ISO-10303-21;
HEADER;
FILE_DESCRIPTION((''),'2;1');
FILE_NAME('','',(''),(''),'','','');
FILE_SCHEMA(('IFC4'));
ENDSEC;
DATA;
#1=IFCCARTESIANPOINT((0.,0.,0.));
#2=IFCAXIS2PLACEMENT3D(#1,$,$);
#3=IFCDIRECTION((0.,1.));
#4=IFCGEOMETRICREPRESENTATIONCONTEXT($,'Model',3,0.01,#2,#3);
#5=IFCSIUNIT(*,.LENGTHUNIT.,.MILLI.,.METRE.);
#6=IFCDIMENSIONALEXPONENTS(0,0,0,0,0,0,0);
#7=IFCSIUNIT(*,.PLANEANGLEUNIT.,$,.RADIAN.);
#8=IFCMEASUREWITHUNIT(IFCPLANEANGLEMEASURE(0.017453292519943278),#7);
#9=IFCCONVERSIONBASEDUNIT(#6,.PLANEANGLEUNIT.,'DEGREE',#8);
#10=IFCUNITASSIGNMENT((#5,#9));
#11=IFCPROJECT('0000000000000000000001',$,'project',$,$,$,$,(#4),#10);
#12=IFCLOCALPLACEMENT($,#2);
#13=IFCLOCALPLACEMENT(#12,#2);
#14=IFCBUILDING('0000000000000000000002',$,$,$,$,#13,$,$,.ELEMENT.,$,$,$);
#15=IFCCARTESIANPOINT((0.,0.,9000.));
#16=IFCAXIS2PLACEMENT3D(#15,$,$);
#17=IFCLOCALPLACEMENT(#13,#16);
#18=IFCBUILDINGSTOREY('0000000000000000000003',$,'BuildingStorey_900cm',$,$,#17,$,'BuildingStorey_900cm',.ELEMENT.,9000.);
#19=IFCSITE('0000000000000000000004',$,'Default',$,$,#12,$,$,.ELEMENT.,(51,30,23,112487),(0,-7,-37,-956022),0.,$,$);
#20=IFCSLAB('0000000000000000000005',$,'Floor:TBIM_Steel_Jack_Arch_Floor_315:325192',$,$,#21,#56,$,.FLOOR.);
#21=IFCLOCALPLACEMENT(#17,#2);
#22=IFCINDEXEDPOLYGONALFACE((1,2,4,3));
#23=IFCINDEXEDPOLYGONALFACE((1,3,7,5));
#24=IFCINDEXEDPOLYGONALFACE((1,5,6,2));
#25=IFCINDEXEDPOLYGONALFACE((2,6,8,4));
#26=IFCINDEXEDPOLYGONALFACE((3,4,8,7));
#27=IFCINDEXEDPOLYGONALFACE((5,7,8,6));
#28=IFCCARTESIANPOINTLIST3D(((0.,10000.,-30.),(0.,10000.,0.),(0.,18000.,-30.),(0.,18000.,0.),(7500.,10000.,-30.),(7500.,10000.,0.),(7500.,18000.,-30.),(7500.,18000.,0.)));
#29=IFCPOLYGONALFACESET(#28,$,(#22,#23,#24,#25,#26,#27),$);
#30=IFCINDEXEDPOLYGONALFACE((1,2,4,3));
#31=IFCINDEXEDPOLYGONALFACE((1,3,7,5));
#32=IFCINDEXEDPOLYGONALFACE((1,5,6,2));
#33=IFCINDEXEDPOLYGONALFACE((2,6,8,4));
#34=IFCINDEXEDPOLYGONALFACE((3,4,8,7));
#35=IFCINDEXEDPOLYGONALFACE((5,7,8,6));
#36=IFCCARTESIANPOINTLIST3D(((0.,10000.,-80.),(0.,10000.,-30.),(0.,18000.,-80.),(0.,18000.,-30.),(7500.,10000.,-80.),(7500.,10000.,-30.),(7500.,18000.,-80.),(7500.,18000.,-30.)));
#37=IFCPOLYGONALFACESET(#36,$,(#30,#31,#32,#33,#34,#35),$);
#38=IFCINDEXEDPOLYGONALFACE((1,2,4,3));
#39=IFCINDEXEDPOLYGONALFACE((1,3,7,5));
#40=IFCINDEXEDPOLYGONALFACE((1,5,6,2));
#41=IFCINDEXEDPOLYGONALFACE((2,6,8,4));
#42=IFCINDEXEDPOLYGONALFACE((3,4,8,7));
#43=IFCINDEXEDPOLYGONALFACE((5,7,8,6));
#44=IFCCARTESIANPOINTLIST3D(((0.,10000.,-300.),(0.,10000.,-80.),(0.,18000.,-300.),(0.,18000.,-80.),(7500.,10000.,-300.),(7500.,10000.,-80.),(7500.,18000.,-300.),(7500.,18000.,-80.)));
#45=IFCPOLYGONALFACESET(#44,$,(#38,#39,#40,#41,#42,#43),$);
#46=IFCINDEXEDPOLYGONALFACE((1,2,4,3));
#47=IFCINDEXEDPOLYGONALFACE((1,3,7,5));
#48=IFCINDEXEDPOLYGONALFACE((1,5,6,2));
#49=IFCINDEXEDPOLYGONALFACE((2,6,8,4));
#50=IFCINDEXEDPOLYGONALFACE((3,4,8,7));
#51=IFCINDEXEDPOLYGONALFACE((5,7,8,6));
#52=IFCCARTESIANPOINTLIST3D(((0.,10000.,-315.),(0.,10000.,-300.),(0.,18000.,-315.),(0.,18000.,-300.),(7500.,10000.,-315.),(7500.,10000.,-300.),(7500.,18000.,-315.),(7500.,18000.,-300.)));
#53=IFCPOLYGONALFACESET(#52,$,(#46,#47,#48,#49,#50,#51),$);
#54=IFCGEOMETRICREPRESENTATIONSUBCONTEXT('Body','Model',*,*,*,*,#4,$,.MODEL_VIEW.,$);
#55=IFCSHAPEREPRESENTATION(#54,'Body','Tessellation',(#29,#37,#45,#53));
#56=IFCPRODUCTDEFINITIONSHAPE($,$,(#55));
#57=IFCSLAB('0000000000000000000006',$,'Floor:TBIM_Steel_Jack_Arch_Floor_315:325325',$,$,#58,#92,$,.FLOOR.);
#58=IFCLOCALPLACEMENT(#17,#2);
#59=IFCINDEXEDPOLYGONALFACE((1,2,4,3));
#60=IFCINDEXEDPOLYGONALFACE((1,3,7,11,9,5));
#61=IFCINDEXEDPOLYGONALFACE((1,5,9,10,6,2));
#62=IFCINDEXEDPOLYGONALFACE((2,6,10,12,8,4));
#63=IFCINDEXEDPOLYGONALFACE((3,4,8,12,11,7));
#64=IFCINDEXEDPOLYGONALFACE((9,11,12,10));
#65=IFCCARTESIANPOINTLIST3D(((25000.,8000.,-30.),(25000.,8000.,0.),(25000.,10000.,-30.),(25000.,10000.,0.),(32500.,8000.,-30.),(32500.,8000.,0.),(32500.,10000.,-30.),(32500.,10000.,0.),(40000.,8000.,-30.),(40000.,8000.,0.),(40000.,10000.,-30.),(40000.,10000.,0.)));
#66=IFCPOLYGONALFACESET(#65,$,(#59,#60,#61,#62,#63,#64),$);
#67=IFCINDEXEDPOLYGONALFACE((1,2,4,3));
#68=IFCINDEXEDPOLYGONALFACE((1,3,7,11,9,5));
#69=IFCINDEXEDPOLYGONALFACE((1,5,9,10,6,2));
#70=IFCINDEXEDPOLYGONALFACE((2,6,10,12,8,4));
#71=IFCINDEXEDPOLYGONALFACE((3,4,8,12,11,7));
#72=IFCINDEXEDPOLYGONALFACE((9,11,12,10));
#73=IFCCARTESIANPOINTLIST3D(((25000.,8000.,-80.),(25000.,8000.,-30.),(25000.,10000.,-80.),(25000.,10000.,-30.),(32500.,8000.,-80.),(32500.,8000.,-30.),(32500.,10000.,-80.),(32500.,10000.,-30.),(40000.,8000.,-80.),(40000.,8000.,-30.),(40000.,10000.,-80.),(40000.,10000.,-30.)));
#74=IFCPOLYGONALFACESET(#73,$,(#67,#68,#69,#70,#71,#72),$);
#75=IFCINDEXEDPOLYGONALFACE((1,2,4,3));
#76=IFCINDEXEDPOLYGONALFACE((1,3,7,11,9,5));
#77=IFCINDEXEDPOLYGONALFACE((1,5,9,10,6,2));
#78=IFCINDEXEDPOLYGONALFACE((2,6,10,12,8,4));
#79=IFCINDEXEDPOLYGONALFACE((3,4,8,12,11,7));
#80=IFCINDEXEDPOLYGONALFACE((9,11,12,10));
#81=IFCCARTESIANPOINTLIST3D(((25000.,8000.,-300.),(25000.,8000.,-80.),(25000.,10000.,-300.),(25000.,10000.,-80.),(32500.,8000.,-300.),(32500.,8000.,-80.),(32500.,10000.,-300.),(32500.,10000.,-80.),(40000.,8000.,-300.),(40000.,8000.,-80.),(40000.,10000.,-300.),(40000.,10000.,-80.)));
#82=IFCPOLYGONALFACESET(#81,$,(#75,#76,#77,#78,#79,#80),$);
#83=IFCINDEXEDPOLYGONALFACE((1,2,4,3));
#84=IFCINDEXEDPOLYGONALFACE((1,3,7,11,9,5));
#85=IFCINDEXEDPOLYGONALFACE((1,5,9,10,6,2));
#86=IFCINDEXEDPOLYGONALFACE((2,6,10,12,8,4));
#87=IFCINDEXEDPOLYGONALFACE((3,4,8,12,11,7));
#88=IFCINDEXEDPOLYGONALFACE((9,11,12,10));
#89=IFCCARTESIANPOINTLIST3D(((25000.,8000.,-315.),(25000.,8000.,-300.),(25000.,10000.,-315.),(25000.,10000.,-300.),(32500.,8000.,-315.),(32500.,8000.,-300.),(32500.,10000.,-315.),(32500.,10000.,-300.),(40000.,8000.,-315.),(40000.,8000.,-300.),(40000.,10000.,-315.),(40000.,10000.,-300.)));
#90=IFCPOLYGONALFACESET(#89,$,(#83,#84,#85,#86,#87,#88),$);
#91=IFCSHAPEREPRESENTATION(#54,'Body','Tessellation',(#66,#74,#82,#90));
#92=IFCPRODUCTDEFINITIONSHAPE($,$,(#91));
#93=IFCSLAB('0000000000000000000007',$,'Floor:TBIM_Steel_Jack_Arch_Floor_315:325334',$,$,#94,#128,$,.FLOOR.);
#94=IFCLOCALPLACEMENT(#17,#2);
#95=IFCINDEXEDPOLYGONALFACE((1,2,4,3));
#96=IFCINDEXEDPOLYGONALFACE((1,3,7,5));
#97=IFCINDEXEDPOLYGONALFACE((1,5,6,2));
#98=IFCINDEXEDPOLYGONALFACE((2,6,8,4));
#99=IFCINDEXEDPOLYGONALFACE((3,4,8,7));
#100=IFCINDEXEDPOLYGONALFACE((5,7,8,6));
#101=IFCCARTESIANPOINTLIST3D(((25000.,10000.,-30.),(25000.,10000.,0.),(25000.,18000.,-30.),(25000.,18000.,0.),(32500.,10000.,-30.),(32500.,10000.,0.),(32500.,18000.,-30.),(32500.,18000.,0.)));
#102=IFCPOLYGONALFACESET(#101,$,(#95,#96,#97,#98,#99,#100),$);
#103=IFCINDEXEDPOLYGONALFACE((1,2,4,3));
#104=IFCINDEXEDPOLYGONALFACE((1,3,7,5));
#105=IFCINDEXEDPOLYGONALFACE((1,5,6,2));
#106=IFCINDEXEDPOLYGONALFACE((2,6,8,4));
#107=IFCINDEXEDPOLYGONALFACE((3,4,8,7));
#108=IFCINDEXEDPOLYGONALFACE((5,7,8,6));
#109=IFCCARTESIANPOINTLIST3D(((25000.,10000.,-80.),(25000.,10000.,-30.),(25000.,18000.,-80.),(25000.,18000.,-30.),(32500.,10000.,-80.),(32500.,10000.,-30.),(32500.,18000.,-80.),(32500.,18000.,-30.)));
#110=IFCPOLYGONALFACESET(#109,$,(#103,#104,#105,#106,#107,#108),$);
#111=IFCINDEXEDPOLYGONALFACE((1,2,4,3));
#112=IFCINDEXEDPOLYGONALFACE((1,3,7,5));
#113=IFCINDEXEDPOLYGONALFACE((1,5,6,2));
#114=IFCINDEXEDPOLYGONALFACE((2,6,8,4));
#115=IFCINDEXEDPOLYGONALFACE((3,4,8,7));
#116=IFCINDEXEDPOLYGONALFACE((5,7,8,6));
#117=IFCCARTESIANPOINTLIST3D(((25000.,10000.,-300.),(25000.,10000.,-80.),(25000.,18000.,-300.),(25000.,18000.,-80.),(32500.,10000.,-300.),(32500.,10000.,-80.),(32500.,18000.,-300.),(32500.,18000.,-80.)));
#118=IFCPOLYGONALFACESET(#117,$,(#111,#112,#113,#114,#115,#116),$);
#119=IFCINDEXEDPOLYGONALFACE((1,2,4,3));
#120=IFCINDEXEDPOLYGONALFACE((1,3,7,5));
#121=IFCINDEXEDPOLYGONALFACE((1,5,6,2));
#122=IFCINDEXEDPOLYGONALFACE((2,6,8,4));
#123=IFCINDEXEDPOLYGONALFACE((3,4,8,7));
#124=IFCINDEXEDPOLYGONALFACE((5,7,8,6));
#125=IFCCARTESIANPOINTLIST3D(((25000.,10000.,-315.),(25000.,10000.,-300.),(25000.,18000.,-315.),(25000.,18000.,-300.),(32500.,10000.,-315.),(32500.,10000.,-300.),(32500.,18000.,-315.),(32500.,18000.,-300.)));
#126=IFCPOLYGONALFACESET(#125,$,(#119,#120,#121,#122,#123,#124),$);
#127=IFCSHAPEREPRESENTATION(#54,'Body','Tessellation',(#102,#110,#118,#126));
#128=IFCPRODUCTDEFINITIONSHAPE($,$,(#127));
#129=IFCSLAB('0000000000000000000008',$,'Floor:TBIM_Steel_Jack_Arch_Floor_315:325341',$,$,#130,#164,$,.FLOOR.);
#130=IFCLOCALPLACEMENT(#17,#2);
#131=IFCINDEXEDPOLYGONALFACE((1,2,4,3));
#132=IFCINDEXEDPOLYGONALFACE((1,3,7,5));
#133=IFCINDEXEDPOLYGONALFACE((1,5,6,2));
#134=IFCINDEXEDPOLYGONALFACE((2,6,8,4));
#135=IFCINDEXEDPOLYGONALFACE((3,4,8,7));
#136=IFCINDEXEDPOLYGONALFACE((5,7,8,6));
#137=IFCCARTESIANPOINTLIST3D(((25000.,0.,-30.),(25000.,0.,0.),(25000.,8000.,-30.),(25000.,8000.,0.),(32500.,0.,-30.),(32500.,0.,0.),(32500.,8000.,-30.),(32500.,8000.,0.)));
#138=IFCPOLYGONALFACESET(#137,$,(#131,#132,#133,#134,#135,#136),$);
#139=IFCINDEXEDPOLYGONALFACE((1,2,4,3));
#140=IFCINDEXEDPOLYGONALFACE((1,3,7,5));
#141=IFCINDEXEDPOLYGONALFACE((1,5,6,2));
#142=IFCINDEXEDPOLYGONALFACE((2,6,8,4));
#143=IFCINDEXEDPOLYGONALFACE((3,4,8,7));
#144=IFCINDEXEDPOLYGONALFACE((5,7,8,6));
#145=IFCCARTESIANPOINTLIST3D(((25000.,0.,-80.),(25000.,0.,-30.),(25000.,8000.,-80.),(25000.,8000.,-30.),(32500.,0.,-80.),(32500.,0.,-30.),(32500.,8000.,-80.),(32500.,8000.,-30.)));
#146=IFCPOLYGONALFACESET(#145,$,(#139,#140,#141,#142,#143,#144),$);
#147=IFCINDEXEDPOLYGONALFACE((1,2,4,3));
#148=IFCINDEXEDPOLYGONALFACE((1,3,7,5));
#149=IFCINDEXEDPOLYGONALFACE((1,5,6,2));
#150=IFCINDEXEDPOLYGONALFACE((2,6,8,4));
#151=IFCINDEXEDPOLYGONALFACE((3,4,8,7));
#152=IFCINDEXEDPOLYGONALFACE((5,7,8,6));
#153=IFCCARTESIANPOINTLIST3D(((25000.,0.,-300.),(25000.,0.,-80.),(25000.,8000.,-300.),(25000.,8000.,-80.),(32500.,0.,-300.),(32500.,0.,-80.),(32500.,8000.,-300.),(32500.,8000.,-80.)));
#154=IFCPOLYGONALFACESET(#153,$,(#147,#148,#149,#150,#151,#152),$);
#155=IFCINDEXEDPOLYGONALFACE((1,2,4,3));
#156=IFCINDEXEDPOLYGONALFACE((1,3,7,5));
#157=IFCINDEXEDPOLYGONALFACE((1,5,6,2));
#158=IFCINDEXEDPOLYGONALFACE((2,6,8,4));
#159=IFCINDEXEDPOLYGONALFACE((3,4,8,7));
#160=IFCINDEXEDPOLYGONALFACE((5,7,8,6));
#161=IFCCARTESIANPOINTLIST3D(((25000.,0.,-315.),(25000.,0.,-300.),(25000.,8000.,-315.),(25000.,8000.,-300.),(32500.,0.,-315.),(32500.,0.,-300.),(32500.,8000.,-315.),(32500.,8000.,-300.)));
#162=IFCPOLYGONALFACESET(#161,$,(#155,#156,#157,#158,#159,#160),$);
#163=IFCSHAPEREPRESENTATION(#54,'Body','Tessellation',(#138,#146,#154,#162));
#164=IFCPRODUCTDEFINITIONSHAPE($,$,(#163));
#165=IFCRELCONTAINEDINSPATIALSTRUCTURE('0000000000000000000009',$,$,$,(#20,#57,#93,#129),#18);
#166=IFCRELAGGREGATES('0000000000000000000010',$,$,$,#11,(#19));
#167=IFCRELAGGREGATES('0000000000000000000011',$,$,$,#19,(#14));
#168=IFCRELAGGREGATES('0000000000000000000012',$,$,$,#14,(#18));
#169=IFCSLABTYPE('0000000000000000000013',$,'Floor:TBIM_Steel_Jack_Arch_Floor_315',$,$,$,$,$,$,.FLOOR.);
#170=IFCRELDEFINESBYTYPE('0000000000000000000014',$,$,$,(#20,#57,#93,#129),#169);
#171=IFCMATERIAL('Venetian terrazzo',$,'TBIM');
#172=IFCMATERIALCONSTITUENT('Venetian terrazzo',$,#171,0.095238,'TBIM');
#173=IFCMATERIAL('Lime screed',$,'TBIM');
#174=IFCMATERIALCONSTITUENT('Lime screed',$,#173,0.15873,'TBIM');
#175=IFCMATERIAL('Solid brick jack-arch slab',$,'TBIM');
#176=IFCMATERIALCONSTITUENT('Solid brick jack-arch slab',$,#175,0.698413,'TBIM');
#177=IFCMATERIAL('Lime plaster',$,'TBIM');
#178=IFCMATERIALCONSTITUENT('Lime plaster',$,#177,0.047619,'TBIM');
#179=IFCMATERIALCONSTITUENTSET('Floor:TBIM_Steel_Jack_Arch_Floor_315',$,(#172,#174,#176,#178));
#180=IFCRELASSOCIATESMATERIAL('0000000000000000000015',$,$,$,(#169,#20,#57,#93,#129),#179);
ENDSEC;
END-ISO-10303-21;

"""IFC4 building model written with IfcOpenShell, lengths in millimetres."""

from ifc_helpers import new_model, entity, si_unit, converted_unit, direction, frame, origin, place, context, subcontext, project, spatial, indexed_curve, outline, extrude, material, constituent, constituent_set, type_object, element, save


model = new_model("IFC4")

# Units and contexts
model_context = context("Model", 3, precision=0.01, world=origin(), true_north=direction((0.0, 1.0)))
body_context = subcontext(model_context, "Body", "Model", "MODEL_VIEW")
ifc_project = project(units=[si_unit("LENGTHUNIT", "METRE", prefix="MILLI"), converted_unit("PLANEANGLEUNIT", "DEGREE", entity("IfcPlaneAngleMeasure", 0.017453292519943278), si_unit("PLANEANGLEUNIT", "RADIAN"), dimensions=[0, 0, 0, 0, 0, 0, 0])], contexts=[model_context])

# Site, building, storey
site_placement = place(None, origin())
site = spatial("IfcSite", under=ifc_project, at=site_placement, Name="Default", CompositionType="ELEMENT", RefLatitude=(51, 30, 23, 112487), RefLongitude=(0, -7, -37, -956022), RefElevation=0.0)
building_placement = place(site_placement, origin())
building = spatial("IfcBuilding", under=site, at=building_placement, CompositionType="ELEMENT")
storey_placement = place(building_placement, frame((0.0, 0.0, 9000.0)))
storey = spatial("IfcBuildingStorey", under=building, at=storey_placement, Name="BuildingStorey_900cm", LongName="BuildingStorey_900cm", CompositionType="ELEMENT", Elevation=9000.0)

# Slabs
ifc_material_1 = material(Name="Venetian terrazzo", Category="TBIM")
ifc_constituent_1 = constituent(ifc_material_1, Name="Venetian terrazzo", Category="TBIM", fraction=0.095238)
ifc_material_2 = material(Name="Lime screed", Category="TBIM")
ifc_constituent_2 = constituent(ifc_material_2, Name="Lime screed", Category="TBIM", fraction=0.15873)
ifc_material_3 = material(Name="Solid brick jack-arch slab", Category="TBIM")
ifc_constituent_3 = constituent(ifc_material_3, Name="Solid brick jack-arch slab", Category="TBIM", fraction=0.698413)
ifc_material_4 = material(Name="Lime plaster", Category="TBIM")
ifc_constituent_4 = constituent(ifc_material_4, Name="Lime plaster", Category="TBIM", fraction=0.047619)
ifc_constituent_set_1 = constituent_set(constituents=[ifc_constituent_1, ifc_constituent_2, ifc_constituent_3, ifc_constituent_4], Name="Floor:TBIM_Steel_Jack_Arch_Floor_315")
slab_type = type_object("IfcSlabType", Name="Floor:TBIM_Steel_Jack_Arch_Floor_315", PredefinedType="FLOOR", material=ifc_constituent_set_1)
slab_1_placement = place(storey_placement, origin())
element("IfcSlab", 1, at=slab_1_placement, inside=storey, type_object=slab_type, material=ifc_constituent_set_1, Name="Floor:TBIM_Steel_Jack_Arch_Floor_315:325192", PredefinedType="FLOOR", context=body_context, shape_type="SweptSolid", body=[
    extrude(outline(indexed_curve([(-3750.0, -4000.0), (3750.0, -4000.0), (3750.0, 4000.0), (-3750.0, 4000.0), (-3750.0, -4000.0)], self_intersect=False)), frame((3750.0, 14000.0, -30.0), z_axis=(0.0, 0.0, 1.0), x_axis=(-1.0, 0.0, 0.0)), (0.0, 0.0, 1.0), 30.0),
    extrude(outline(indexed_curve([(-3750.0, -4000.0), (3750.0, -4000.0), (3750.0, 4000.0), (-3750.0, 4000.0), (-3750.0, -4000.0)], self_intersect=False)), frame((3750.0, 14000.0, -80.0), z_axis=(0.0, 0.0, 1.0), x_axis=(-1.0, 0.0, 0.0)), (0.0, 0.0, 1.0), 50.0),
    extrude(outline(indexed_curve([(-3750.0, -4000.0), (3750.0, -4000.0), (3750.0, 4000.0), (-3750.0, 4000.0), (-3750.0, -4000.0)], self_intersect=False)), frame((3750.0, 14000.0, -300.0), z_axis=(0.0, 0.0, 1.0), x_axis=(-1.0, 0.0, 0.0)), (0.0, 0.0, 1.0), 220.0),
    extrude(outline(indexed_curve([(-3750.0, -4000.0), (3750.0, -4000.0), (3750.0, 4000.0), (-3750.0, 4000.0), (-3750.0, -4000.0)], self_intersect=False)), frame((3750.0, 14000.0, -315.0), z_axis=(0.0, 0.0, 1.0), x_axis=(-1.0, 0.0, 0.0)), (0.0, 0.0, 1.0), 15.0),
])
slab_2_placement = place(storey_placement, origin())
element("IfcSlab", 2, at=slab_2_placement, inside=storey, type_object=slab_type, material=ifc_constituent_set_1, Name="Floor:TBIM_Steel_Jack_Arch_Floor_315:325325", PredefinedType="FLOOR", context=body_context, shape_type="SweptSolid", body=[
    extrude(outline(indexed_curve([(-7500.0, -1000.0), (0.0, -1000.0), (7500.0, -1000.0), (7500.0, 1000.0), (0.0, 1000.0), (-7500.0, 1000.0), (-7500.0, -1000.0)], self_intersect=False)), frame((32500.0, 9000.0, -30.0), z_axis=(0.0, 0.0, 1.0), x_axis=(-1.0, 0.0, 0.0)), (0.0, 0.0, 1.0), 30.0),
    extrude(outline(indexed_curve([(-7500.0, -1000.0), (0.0, -1000.0), (7500.0, -1000.0), (7500.0, 1000.0), (0.0, 1000.0), (-7500.0, 1000.0), (-7500.0, -1000.0)], self_intersect=False)), frame((32500.0, 9000.0, -80.0), z_axis=(0.0, 0.0, 1.0), x_axis=(-1.0, 0.0, 0.0)), (0.0, 0.0, 1.0), 50.0),
    extrude(outline(indexed_curve([(-7500.0, -1000.0), (0.0, -1000.0), (7500.0, -1000.0), (7500.0, 1000.0), (0.0, 1000.0), (-7500.0, 1000.0), (-7500.0, -1000.0)], self_intersect=False)), frame((32500.0, 9000.0, -300.0), z_axis=(0.0, 0.0, 1.0), x_axis=(-1.0, 0.0, 0.0)), (0.0, 0.0, 1.0), 220.0),
    extrude(outline(indexed_curve([(-7500.0, -1000.0), (0.0, -1000.0), (7500.0, -1000.0), (7500.0, 1000.0), (0.0, 1000.0), (-7500.0, 1000.0), (-7500.0, -1000.0)], self_intersect=False)), frame((32500.0, 9000.0, -315.0), z_axis=(0.0, 0.0, 1.0), x_axis=(-1.0, 0.0, 0.0)), (0.0, 0.0, 1.0), 15.0),
])
slab_3_placement = place(storey_placement, origin())
element("IfcSlab", 3, at=slab_3_placement, inside=storey, type_object=slab_type, material=ifc_constituent_set_1, Name="Floor:TBIM_Steel_Jack_Arch_Floor_315:325334", PredefinedType="FLOOR", context=body_context, shape_type="SweptSolid", body=[
    extrude(outline(indexed_curve([(-3750.0, -4000.0), (3750.0, -4000.0), (3750.0, 4000.0), (-3750.0, 4000.0), (-3750.0, -4000.0)], self_intersect=False)), frame((28750.0, 14000.0, -30.0), z_axis=(0.0, 0.0, 1.0), x_axis=(-1.0, 0.0, 0.0)), (0.0, 0.0, 1.0), 30.0),
    extrude(outline(indexed_curve([(-3750.0, -4000.0), (3750.0, -4000.0), (3750.0, 4000.0), (-3750.0, 4000.0), (-3750.0, -4000.0)], self_intersect=False)), frame((28750.0, 14000.0, -80.0), z_axis=(0.0, 0.0, 1.0), x_axis=(-1.0, 0.0, 0.0)), (0.0, 0.0, 1.0), 50.0),
    extrude(outline(indexed_curve([(-3750.0, -4000.0), (3750.0, -4000.0), (3750.0, 4000.0), (-3750.0, 4000.0), (-3750.0, -4000.0)], self_intersect=False)), frame((28750.0, 14000.0, -300.0), z_axis=(0.0, 0.0, 1.0), x_axis=(-1.0, 0.0, 0.0)), (0.0, 0.0, 1.0), 220.0),
    extrude(outline(indexed_curve([(-3750.0, -4000.0), (3750.0, -4000.0), (3750.0, 4000.0), (-3750.0, 4000.0), (-3750.0, -4000.0)], self_intersect=False)), frame((28750.0, 14000.0, -315.0), z_axis=(0.0, 0.0, 1.0), x_axis=(-1.0, 0.0, 0.0)), (0.0, 0.0, 1.0), 15.0),
])
slab_4_placement = place(storey_placement, origin())
element("IfcSlab", 4, at=slab_4_placement, inside=storey, type_object=slab_type, material=ifc_constituent_set_1, Name="Floor:TBIM_Steel_Jack_Arch_Floor_315:325341", PredefinedType="FLOOR", context=body_context, shape_type="SweptSolid", body=[
    extrude(outline(indexed_curve([(-3750.0, -4000.0), (3750.0, -4000.0), (3750.0, 4000.0), (-3750.0, 4000.0), (-3750.0, -4000.0)], self_intersect=False)), frame((28750.0, 4000.0, -30.0), z_axis=(0.0, 0.0, 1.0), x_axis=(-1.0, 0.0, 0.0)), (0.0, 0.0, 1.0), 30.0),
    extrude(outline(indexed_curve([(-3750.0, -4000.0), (3750.0, -4000.0), (3750.0, 4000.0), (-3750.0, 4000.0), (-3750.0, -4000.0)], self_intersect=False)), frame((28750.0, 4000.0, -80.0), z_axis=(0.0, 0.0, 1.0), x_axis=(-1.0, 0.0, 0.0)), (0.0, 0.0, 1.0), 50.0),
    extrude(outline(indexed_curve([(-3750.0, -4000.0), (3750.0, -4000.0), (3750.0, 4000.0), (-3750.0, 4000.0), (-3750.0, -4000.0)], self_intersect=False)), frame((28750.0, 4000.0, -300.0), z_axis=(0.0, 0.0, 1.0), x_axis=(-1.0, 0.0, 0.0)), (0.0, 0.0, 1.0), 220.0),
    extrude(outline(indexed_curve([(-3750.0, -4000.0), (3750.0, -4000.0), (3750.0, 4000.0), (-3750.0, 4000.0), (-3750.0, -4000.0)], self_intersect=False)), frame((28750.0, 4000.0, -315.0), z_axis=(0.0, 0.0, 1.0), x_axis=(-1.0, 0.0, 0.0)), (0.0, 0.0, 1.0), 15.0),
])

save(model, "model.ifc")
